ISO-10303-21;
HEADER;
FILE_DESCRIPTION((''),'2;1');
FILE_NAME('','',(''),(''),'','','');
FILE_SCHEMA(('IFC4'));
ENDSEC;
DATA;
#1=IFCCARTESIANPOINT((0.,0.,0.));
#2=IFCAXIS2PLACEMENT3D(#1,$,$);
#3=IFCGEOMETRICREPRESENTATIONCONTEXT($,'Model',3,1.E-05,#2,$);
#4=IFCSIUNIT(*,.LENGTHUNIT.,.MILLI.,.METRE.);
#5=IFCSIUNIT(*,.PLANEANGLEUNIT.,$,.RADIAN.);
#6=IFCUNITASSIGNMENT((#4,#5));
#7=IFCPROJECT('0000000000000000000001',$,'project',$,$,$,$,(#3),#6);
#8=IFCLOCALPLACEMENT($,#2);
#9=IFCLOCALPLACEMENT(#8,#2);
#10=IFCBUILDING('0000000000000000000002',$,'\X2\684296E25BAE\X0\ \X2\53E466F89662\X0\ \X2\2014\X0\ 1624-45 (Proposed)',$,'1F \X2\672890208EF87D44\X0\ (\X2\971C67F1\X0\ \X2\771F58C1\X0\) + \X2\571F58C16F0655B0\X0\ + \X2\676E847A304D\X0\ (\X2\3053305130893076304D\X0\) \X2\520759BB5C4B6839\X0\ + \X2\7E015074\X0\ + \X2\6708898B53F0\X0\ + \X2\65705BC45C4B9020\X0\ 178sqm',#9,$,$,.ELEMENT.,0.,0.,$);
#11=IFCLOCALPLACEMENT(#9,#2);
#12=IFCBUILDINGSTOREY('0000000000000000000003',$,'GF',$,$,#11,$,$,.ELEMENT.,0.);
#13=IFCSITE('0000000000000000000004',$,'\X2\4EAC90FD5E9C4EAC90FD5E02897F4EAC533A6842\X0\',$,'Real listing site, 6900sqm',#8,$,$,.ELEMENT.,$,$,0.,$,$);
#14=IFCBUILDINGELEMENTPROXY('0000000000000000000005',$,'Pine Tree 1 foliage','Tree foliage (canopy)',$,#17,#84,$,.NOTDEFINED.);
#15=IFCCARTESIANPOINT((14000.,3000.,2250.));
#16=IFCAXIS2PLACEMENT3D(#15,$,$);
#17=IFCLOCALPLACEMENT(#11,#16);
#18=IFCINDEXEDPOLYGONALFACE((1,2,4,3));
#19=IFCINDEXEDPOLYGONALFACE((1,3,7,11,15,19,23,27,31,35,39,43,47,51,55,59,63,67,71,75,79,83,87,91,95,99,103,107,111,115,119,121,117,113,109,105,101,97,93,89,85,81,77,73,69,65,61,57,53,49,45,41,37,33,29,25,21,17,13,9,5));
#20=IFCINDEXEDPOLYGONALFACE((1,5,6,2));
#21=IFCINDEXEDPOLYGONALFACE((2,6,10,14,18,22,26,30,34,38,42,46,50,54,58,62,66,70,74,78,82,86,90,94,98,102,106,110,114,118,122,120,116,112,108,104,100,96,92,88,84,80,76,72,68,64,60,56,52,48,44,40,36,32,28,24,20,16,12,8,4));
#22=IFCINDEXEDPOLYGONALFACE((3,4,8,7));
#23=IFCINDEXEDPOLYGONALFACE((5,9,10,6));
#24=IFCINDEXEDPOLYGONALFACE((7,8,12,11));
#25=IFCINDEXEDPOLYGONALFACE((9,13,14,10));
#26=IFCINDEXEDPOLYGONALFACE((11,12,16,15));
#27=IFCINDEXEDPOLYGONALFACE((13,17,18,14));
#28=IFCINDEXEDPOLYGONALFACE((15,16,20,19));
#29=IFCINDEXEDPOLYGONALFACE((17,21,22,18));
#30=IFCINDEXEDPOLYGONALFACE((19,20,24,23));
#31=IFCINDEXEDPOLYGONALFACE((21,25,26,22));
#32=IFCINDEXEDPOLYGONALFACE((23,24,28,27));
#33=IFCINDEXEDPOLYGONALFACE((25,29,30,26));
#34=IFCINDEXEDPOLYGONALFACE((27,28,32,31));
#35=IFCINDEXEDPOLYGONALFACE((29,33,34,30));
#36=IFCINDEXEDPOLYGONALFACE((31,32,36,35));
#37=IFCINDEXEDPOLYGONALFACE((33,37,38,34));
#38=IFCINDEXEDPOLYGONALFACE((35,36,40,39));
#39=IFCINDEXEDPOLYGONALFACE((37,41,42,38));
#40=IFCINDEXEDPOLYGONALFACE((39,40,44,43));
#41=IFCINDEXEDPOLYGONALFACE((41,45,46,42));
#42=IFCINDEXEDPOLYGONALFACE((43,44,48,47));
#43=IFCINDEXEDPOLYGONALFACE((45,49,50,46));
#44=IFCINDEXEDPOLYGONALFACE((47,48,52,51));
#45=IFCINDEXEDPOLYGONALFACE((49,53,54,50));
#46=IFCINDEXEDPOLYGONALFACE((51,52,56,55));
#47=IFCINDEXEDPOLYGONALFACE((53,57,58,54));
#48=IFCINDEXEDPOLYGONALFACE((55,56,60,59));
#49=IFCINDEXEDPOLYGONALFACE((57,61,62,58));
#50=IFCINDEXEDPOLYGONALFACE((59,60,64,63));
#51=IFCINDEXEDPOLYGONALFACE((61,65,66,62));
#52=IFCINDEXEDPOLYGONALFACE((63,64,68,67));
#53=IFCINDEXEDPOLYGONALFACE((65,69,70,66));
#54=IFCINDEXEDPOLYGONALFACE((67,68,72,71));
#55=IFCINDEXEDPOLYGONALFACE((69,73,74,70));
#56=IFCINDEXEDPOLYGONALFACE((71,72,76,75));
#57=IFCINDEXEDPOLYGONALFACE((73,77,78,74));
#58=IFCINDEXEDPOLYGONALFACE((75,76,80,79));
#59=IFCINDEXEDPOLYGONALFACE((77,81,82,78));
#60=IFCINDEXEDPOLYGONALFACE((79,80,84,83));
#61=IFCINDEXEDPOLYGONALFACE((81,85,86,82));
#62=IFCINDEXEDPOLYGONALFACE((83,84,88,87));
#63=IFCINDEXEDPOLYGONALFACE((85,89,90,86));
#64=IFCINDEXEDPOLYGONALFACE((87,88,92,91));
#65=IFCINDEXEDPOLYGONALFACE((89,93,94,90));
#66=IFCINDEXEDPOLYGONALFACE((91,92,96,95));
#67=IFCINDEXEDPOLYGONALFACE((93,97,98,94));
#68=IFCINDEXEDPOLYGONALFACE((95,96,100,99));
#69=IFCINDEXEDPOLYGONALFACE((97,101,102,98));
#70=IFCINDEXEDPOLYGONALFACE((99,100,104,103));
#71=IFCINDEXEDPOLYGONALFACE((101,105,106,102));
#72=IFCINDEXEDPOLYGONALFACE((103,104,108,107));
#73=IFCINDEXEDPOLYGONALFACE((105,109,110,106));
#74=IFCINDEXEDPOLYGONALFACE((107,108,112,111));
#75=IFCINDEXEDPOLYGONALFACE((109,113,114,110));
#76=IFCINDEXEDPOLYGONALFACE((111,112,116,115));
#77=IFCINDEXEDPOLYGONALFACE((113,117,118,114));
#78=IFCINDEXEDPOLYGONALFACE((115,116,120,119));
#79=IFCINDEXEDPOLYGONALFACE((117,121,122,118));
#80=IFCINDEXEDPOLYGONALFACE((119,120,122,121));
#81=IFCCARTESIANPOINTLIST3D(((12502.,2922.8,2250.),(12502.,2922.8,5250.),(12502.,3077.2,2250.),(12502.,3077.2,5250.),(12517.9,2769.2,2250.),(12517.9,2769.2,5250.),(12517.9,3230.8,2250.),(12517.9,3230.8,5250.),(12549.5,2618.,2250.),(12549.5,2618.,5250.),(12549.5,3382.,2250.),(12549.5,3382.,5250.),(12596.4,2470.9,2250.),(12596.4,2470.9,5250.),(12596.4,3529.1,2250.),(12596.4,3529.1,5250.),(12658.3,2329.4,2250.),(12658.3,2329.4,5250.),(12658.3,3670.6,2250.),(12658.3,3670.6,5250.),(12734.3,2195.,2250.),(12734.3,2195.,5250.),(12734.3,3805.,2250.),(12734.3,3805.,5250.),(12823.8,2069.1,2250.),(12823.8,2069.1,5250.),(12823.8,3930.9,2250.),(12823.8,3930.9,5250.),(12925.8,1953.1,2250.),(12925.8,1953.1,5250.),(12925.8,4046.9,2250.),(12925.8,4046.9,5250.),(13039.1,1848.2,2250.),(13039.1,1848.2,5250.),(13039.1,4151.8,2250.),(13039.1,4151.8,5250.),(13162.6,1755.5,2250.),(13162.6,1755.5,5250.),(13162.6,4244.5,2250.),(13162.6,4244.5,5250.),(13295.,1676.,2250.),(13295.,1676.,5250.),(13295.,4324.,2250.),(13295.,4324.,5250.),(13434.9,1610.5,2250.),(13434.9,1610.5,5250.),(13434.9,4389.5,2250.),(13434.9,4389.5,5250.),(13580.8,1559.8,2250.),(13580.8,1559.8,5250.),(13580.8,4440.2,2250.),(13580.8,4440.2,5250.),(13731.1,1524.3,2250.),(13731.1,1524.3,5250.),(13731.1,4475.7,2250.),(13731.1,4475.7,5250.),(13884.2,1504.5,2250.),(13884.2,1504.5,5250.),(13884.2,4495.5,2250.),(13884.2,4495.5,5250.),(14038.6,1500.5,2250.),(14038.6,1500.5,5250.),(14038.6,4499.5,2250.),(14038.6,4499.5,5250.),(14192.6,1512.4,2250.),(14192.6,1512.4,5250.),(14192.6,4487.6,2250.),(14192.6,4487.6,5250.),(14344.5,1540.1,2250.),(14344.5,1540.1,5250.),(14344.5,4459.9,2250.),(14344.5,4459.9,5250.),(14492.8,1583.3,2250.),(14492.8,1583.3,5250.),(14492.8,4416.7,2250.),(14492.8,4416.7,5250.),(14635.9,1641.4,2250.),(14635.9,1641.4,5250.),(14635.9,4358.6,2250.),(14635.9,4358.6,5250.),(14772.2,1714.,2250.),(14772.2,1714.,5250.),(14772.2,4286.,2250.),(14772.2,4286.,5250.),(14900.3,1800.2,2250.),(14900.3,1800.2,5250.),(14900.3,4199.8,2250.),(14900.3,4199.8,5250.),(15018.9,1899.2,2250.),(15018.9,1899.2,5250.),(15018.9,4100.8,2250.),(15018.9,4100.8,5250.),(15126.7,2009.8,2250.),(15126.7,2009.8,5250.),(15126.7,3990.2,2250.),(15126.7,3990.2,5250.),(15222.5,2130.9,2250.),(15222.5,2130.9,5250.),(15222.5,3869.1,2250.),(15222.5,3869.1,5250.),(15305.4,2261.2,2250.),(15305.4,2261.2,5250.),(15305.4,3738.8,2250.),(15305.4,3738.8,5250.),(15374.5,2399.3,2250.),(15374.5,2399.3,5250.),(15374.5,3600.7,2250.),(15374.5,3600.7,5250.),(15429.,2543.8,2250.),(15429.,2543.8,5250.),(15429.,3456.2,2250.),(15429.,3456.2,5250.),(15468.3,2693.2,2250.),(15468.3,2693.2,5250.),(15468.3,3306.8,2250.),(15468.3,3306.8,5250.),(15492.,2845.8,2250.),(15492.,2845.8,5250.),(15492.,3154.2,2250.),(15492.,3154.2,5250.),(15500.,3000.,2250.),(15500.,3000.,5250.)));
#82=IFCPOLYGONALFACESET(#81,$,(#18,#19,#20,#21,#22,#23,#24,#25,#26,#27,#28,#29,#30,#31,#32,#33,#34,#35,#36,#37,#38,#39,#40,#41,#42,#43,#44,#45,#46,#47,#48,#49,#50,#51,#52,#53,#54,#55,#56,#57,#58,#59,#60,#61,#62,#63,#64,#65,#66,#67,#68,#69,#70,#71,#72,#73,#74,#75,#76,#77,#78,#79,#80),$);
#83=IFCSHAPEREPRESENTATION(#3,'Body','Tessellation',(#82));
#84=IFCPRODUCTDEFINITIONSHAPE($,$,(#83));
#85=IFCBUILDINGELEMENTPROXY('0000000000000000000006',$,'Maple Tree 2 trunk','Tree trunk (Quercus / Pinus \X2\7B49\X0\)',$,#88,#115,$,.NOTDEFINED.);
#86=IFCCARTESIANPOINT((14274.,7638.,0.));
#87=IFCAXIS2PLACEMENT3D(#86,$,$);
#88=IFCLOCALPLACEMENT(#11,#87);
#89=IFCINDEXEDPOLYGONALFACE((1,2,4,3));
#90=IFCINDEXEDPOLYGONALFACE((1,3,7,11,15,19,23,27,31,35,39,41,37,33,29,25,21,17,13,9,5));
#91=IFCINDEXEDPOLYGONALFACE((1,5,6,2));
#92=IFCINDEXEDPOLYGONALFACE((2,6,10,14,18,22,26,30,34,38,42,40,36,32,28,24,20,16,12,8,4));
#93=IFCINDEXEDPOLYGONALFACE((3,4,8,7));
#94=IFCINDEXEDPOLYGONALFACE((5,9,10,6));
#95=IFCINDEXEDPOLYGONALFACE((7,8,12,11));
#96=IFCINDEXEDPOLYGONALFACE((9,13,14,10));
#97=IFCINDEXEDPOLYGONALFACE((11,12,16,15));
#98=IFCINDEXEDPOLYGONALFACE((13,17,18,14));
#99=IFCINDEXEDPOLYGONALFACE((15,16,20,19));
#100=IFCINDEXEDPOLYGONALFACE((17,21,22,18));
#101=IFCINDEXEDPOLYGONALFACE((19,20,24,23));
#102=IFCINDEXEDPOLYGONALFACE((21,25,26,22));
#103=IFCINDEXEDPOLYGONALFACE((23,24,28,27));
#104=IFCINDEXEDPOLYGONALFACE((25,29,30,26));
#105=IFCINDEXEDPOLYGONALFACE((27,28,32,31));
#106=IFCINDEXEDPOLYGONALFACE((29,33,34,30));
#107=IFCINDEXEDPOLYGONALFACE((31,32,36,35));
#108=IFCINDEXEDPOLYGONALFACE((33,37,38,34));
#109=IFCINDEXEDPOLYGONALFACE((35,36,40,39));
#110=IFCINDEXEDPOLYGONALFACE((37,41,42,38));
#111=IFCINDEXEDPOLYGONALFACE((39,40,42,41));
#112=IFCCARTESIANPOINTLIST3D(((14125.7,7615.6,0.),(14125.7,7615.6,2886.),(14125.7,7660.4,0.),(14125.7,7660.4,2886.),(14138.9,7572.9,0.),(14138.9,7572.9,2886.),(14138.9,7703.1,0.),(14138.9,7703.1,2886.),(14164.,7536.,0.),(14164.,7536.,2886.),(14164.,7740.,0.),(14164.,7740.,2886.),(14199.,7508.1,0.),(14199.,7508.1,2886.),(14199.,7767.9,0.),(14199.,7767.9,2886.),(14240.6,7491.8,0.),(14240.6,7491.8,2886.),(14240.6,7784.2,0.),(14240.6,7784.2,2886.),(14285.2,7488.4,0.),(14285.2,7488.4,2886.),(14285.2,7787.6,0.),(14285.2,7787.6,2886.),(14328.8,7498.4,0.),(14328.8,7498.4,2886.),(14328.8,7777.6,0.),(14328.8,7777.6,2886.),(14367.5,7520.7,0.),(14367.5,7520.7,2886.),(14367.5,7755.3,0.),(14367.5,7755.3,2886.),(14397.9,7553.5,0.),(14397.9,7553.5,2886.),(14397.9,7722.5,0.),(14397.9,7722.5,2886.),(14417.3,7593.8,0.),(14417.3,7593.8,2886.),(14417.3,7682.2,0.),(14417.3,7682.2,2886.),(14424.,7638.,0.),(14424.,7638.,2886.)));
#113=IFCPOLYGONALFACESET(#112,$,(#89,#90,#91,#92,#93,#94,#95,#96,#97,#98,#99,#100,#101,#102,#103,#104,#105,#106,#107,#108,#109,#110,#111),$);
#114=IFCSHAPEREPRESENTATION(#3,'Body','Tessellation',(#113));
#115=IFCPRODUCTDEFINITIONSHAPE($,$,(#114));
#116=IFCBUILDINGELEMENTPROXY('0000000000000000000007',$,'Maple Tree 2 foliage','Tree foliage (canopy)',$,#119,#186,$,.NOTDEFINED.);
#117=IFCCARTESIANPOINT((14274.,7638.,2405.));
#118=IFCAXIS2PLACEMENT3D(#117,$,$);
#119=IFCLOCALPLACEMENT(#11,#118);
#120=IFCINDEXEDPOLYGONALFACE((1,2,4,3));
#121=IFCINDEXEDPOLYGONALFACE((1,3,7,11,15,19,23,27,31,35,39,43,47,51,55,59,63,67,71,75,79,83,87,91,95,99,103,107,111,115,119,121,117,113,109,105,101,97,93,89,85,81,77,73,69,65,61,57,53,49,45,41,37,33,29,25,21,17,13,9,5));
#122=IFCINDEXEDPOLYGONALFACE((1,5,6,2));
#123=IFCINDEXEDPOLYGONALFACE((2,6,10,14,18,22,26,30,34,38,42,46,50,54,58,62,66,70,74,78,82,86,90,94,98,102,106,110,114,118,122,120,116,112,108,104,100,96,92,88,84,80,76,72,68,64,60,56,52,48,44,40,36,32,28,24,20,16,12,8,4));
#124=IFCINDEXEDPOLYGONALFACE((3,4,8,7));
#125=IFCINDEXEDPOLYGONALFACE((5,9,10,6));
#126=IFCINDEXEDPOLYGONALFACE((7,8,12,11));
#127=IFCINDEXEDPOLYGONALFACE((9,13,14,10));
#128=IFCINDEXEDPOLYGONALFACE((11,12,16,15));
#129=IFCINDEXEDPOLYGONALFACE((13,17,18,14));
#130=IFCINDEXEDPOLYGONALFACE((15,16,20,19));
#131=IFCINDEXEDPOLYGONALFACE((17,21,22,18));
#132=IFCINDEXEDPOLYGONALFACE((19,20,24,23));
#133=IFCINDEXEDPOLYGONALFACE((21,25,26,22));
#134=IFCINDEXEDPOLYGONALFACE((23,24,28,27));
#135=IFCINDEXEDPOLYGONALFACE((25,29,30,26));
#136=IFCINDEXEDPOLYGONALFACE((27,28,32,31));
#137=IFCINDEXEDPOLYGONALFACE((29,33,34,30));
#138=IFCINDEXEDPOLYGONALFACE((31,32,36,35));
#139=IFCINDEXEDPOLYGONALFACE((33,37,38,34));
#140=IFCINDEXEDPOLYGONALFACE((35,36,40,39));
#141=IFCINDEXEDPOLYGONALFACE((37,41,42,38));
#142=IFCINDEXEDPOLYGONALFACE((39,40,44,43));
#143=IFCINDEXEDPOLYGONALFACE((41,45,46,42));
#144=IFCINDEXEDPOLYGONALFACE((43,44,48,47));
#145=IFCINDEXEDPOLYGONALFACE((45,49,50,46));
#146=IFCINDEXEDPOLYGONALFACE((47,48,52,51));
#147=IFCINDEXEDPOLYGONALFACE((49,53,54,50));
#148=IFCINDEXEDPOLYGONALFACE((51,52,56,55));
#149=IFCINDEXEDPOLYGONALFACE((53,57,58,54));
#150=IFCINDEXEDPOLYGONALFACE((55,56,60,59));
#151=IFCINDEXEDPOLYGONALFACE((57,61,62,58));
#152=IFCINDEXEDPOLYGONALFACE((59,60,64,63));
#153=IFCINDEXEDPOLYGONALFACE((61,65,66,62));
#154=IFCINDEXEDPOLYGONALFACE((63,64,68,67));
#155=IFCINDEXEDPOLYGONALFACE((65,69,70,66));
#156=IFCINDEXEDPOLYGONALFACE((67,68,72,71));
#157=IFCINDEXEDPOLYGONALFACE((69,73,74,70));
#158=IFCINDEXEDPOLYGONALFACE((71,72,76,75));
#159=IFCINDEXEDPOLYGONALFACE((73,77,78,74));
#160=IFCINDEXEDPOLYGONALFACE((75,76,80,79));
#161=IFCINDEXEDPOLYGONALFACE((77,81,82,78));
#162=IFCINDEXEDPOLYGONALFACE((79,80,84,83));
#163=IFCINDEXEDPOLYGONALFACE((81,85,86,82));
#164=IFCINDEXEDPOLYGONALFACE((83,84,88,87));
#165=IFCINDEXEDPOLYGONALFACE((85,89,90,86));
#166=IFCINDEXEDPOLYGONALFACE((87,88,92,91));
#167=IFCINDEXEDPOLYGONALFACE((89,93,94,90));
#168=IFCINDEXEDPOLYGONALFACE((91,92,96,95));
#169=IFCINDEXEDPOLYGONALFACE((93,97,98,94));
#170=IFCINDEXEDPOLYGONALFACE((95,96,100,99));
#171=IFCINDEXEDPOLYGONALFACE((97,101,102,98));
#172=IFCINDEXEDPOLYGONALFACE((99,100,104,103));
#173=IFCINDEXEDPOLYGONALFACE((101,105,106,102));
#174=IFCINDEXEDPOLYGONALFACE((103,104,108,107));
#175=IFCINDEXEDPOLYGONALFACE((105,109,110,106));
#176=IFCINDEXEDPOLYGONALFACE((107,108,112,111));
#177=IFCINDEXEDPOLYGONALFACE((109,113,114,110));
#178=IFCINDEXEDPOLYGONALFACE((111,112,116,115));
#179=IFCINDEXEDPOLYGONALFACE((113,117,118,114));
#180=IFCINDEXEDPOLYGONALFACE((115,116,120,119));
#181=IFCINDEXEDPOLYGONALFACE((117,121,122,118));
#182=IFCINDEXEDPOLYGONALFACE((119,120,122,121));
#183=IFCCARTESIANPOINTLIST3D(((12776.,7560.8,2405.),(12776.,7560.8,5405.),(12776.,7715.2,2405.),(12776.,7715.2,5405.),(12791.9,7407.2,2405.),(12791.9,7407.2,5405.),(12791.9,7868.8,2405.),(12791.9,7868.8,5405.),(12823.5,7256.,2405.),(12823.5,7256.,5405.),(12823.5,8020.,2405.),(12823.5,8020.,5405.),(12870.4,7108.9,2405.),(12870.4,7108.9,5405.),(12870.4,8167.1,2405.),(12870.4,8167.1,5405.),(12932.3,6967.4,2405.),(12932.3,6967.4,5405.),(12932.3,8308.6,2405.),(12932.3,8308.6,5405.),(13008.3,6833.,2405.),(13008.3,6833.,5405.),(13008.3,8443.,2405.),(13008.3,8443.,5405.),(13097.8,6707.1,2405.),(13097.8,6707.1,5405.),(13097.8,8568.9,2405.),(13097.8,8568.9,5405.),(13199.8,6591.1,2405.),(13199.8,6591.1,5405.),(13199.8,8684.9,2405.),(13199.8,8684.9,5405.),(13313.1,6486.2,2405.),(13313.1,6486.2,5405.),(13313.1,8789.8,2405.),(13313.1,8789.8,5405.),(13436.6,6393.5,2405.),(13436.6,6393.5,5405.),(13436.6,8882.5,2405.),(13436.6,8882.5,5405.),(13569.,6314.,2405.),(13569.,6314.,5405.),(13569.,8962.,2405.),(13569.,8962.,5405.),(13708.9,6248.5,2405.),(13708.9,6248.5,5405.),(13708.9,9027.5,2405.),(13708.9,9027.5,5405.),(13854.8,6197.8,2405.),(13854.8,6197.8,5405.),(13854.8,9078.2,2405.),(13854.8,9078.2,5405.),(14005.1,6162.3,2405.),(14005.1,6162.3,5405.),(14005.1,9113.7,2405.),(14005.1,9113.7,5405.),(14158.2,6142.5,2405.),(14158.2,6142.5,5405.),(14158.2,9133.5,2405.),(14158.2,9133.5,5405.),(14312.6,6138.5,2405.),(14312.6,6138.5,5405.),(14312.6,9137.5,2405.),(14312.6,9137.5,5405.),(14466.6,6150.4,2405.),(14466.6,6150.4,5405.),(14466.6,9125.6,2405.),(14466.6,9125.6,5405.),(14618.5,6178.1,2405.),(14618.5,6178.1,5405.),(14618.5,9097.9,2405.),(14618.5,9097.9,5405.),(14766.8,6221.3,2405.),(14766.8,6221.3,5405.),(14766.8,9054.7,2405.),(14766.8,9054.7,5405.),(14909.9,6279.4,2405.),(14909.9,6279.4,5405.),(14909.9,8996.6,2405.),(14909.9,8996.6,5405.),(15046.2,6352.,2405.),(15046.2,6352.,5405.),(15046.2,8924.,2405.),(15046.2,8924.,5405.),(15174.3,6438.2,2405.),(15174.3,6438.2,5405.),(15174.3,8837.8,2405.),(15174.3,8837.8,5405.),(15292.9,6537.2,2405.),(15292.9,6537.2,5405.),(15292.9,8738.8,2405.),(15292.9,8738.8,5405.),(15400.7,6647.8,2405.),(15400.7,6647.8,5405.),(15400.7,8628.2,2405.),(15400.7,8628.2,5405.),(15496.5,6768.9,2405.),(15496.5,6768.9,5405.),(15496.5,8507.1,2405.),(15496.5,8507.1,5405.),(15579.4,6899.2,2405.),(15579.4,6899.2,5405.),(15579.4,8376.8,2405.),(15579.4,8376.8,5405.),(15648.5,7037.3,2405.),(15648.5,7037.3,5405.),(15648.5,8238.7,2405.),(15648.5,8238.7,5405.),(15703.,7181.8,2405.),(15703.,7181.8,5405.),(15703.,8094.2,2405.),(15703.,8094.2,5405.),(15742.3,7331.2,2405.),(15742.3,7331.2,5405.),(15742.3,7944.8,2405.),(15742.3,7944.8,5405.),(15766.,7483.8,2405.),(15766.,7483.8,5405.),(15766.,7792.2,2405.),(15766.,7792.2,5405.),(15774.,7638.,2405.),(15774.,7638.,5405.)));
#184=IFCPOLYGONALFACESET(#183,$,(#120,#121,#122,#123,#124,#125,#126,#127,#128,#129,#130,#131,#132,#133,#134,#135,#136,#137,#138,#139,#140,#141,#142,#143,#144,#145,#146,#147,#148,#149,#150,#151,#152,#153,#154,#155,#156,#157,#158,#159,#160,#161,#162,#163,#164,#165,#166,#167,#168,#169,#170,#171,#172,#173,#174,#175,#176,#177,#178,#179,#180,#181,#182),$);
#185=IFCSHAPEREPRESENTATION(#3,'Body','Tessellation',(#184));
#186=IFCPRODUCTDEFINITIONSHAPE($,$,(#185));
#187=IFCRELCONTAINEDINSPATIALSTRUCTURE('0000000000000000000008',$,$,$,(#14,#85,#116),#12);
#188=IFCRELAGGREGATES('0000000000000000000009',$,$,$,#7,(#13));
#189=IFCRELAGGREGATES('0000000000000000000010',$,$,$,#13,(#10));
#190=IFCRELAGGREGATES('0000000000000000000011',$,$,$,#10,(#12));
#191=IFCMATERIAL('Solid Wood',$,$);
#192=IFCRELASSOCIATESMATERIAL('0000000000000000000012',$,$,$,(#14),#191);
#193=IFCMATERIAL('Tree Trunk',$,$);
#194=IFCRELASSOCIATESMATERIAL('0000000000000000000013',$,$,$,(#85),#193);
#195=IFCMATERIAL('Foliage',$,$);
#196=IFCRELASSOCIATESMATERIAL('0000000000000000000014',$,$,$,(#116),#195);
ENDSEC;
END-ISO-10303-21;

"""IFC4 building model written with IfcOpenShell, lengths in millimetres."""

from ifc_helpers import new_model, si_unit, frame, origin, origin_2d, place, context, project, spatial, circle, extrude, material, element, save


model = new_model("IFC4")

# Units and contexts
model_context = context("Model", 3, precision=1e-05, world=origin())
ifc_project = project(units=[si_unit("LENGTHUNIT", "METRE", prefix="MILLI"), si_unit("PLANEANGLEUNIT", "RADIAN")], contexts=[model_context])

# Site, building, storey
site_placement = place(None, origin())
site = spatial("IfcSite", under=ifc_project, at=site_placement, Name="京都府京都市西京区桂", ObjectType="Real listing site, 6900sqm", CompositionType="ELEMENT", RefElevation=0.0)
building_placement = place(site_placement, origin())
building = spatial("IfcBuilding", under=site, at=building_placement, Name="桂離宮 古書院 — 1624-45 (Proposed)", ObjectType="1F 木造軸組 (霜柱 真壁) + 土壁漆喰 + 杮葺き (こけらぶき) 切妻屋根 + 縁側 + 月見台 + 数寄屋造 178sqm", CompositionType="ELEMENT", ElevationOfRefHeight=0.0, ElevationOfTerrain=0.0)
storey_placement = place(building_placement, origin())
storey = spatial("IfcBuildingStorey", under=building, at=storey_placement, Name="GF", CompositionType="ELEMENT", Elevation=0.0)

# Shared definitions
ifc_material_1 = material(Name="Solid Wood")

# Building element proxies
proxy_1_placement = place(storey_placement, frame((14000.0, 3000.0, 2250.0)))
element("IfcBuildingElementProxy", 1, at=proxy_1_placement, inside=storey, material=ifc_material_1, Name="Pine Tree 1 foliage", Description="Tree foliage (canopy)", PredefinedType="NOTDEFINED", context=model_context, shape_type="SweptSolid", body=[
    extrude(circle(Radius=1500.0, at=origin_2d()), frame((14000.0, 3000.0, 2250.0)), (0.0, 0.0, 1.0), 3000.0),
])
ifc_material_2 = material(Name="Tree Trunk")
proxy_2_placement = place(storey_placement, frame((14274.0, 7638.0, 0.0)))
element("IfcBuildingElementProxy", 2, at=proxy_2_placement, inside=storey, material=ifc_material_2, Name="Maple Tree 2 trunk", Description="Tree trunk (Quercus / Pinus 等)", PredefinedType="NOTDEFINED", context=model_context, shape_type="SweptSolid", body=[
    extrude(circle(Radius=150.0, at=origin_2d()), frame((14274.0, 7638.0, 0.0)), (0.0, 0.0, 1.0), 2886.0),
])
ifc_material_3 = material(Name="Foliage")
proxy_3_placement = place(storey_placement, frame((14274.0, 7638.0, 2405.0)))
element("IfcBuildingElementProxy", 3, at=proxy_3_placement, inside=storey, material=ifc_material_3, Name="Maple Tree 2 foliage", Description="Tree foliage (canopy)", PredefinedType="NOTDEFINED", context=model_context, shape_type="SweptSolid", body=[
    extrude(circle(Radius=1500.0, at=origin_2d()), frame((14274.0, 7638.0, 2405.0)), (0.0, 0.0, 1.0), 3000.0),
])

save(model, "model.ifc")
